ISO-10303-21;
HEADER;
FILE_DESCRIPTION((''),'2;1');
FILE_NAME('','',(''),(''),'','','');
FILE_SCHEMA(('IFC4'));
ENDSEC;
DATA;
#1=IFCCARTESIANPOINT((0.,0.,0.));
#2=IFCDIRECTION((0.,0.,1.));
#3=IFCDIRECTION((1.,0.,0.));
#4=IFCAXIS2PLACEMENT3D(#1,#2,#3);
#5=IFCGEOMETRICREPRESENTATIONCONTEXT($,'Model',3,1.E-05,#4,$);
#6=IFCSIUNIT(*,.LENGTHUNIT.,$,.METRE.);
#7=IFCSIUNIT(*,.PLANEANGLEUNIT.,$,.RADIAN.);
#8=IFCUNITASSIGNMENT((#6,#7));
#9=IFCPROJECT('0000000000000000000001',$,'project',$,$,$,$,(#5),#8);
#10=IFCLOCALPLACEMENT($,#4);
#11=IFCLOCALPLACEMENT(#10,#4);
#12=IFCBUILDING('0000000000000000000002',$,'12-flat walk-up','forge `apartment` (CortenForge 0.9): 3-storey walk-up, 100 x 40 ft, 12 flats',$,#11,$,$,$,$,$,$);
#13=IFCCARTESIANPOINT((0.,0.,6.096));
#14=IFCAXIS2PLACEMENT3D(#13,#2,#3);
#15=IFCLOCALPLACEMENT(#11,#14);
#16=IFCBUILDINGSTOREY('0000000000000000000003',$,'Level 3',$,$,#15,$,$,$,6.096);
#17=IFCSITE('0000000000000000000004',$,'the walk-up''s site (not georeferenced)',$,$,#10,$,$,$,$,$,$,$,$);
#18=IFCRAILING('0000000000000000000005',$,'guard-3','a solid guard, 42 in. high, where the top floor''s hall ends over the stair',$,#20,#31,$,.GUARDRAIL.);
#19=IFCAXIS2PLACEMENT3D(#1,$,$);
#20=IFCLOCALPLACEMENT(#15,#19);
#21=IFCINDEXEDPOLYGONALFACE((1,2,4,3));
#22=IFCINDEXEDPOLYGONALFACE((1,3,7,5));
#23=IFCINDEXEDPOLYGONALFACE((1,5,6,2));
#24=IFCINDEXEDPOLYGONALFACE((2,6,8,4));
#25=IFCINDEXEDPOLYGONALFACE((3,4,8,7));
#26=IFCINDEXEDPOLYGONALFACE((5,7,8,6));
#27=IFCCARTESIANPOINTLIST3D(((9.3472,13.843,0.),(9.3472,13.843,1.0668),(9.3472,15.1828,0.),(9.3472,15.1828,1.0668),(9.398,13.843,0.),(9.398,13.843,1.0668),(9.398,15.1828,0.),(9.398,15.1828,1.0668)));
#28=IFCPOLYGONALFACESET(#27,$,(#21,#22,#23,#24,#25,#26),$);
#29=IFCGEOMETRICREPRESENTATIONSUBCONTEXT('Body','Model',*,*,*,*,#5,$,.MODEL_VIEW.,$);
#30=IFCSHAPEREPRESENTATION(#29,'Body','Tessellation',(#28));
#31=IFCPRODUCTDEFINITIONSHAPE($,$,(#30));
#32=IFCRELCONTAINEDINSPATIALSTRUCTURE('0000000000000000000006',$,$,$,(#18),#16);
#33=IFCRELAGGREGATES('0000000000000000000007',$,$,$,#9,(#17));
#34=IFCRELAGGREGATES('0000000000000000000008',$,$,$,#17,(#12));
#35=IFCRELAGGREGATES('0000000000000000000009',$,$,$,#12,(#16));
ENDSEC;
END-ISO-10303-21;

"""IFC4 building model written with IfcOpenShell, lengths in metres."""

from ifc_helpers import new_model, si_unit, frame, frame_2d, origin, origin_with_axes, place, context, subcontext, project, spatial, rectangle, extrude, element, save


model = new_model("IFC4")

# Units and contexts
model_context = context("Model", 3, precision=1e-05, world=origin_with_axes())
body_context = subcontext(model_context, "Body", "Model", "MODEL_VIEW")
ifc_project = project(units=[si_unit("LENGTHUNIT", "METRE"), si_unit("PLANEANGLEUNIT", "RADIAN")], contexts=[model_context])

# Site, building, storey
site_placement = place(None, origin_with_axes())
site = spatial("IfcSite", under=ifc_project, at=site_placement, Name="the walk-up's site (not georeferenced)")
building_placement = place(site_placement, origin_with_axes())
building = spatial("IfcBuilding", under=site, at=building_placement, Name="12-flat walk-up", Description="forge `apartment` (CortenForge 0.9): 3-storey walk-up, 100 x 40 ft, 12 flats")
storey_placement = place(building_placement, frame((0.0, 0.0, 6.096), z_axis=(0.0, 0.0, 1.0), x_axis=(1.0, 0.0, 0.0)))
storey = spatial("IfcBuildingStorey", under=building, at=storey_placement, Name="Level 3", Elevation=6.096)

# Railing
railing_placement = place(storey_placement, frame((9.3472, 13.843, 0.0), z_axis=(0.0, 0.0, 1.0), x_axis=(1.0, 0.0, 0.0)))
element("IfcRailing", 1, at=railing_placement, inside=storey, Name="guard-3", Description="a solid guard, 42 in. high, where the top floor's hall ends over the stair", PredefinedType="GUARDRAIL", context=body_context, shape_type="SweptSolid", body=[
    extrude(rectangle(XDim=0.0508, YDim=1.3399, at=frame_2d((0.0254, 0.6699))), origin(), (0.0, 0.0, 1.0), 1.0668),
])

save(model, "model.ifc")
